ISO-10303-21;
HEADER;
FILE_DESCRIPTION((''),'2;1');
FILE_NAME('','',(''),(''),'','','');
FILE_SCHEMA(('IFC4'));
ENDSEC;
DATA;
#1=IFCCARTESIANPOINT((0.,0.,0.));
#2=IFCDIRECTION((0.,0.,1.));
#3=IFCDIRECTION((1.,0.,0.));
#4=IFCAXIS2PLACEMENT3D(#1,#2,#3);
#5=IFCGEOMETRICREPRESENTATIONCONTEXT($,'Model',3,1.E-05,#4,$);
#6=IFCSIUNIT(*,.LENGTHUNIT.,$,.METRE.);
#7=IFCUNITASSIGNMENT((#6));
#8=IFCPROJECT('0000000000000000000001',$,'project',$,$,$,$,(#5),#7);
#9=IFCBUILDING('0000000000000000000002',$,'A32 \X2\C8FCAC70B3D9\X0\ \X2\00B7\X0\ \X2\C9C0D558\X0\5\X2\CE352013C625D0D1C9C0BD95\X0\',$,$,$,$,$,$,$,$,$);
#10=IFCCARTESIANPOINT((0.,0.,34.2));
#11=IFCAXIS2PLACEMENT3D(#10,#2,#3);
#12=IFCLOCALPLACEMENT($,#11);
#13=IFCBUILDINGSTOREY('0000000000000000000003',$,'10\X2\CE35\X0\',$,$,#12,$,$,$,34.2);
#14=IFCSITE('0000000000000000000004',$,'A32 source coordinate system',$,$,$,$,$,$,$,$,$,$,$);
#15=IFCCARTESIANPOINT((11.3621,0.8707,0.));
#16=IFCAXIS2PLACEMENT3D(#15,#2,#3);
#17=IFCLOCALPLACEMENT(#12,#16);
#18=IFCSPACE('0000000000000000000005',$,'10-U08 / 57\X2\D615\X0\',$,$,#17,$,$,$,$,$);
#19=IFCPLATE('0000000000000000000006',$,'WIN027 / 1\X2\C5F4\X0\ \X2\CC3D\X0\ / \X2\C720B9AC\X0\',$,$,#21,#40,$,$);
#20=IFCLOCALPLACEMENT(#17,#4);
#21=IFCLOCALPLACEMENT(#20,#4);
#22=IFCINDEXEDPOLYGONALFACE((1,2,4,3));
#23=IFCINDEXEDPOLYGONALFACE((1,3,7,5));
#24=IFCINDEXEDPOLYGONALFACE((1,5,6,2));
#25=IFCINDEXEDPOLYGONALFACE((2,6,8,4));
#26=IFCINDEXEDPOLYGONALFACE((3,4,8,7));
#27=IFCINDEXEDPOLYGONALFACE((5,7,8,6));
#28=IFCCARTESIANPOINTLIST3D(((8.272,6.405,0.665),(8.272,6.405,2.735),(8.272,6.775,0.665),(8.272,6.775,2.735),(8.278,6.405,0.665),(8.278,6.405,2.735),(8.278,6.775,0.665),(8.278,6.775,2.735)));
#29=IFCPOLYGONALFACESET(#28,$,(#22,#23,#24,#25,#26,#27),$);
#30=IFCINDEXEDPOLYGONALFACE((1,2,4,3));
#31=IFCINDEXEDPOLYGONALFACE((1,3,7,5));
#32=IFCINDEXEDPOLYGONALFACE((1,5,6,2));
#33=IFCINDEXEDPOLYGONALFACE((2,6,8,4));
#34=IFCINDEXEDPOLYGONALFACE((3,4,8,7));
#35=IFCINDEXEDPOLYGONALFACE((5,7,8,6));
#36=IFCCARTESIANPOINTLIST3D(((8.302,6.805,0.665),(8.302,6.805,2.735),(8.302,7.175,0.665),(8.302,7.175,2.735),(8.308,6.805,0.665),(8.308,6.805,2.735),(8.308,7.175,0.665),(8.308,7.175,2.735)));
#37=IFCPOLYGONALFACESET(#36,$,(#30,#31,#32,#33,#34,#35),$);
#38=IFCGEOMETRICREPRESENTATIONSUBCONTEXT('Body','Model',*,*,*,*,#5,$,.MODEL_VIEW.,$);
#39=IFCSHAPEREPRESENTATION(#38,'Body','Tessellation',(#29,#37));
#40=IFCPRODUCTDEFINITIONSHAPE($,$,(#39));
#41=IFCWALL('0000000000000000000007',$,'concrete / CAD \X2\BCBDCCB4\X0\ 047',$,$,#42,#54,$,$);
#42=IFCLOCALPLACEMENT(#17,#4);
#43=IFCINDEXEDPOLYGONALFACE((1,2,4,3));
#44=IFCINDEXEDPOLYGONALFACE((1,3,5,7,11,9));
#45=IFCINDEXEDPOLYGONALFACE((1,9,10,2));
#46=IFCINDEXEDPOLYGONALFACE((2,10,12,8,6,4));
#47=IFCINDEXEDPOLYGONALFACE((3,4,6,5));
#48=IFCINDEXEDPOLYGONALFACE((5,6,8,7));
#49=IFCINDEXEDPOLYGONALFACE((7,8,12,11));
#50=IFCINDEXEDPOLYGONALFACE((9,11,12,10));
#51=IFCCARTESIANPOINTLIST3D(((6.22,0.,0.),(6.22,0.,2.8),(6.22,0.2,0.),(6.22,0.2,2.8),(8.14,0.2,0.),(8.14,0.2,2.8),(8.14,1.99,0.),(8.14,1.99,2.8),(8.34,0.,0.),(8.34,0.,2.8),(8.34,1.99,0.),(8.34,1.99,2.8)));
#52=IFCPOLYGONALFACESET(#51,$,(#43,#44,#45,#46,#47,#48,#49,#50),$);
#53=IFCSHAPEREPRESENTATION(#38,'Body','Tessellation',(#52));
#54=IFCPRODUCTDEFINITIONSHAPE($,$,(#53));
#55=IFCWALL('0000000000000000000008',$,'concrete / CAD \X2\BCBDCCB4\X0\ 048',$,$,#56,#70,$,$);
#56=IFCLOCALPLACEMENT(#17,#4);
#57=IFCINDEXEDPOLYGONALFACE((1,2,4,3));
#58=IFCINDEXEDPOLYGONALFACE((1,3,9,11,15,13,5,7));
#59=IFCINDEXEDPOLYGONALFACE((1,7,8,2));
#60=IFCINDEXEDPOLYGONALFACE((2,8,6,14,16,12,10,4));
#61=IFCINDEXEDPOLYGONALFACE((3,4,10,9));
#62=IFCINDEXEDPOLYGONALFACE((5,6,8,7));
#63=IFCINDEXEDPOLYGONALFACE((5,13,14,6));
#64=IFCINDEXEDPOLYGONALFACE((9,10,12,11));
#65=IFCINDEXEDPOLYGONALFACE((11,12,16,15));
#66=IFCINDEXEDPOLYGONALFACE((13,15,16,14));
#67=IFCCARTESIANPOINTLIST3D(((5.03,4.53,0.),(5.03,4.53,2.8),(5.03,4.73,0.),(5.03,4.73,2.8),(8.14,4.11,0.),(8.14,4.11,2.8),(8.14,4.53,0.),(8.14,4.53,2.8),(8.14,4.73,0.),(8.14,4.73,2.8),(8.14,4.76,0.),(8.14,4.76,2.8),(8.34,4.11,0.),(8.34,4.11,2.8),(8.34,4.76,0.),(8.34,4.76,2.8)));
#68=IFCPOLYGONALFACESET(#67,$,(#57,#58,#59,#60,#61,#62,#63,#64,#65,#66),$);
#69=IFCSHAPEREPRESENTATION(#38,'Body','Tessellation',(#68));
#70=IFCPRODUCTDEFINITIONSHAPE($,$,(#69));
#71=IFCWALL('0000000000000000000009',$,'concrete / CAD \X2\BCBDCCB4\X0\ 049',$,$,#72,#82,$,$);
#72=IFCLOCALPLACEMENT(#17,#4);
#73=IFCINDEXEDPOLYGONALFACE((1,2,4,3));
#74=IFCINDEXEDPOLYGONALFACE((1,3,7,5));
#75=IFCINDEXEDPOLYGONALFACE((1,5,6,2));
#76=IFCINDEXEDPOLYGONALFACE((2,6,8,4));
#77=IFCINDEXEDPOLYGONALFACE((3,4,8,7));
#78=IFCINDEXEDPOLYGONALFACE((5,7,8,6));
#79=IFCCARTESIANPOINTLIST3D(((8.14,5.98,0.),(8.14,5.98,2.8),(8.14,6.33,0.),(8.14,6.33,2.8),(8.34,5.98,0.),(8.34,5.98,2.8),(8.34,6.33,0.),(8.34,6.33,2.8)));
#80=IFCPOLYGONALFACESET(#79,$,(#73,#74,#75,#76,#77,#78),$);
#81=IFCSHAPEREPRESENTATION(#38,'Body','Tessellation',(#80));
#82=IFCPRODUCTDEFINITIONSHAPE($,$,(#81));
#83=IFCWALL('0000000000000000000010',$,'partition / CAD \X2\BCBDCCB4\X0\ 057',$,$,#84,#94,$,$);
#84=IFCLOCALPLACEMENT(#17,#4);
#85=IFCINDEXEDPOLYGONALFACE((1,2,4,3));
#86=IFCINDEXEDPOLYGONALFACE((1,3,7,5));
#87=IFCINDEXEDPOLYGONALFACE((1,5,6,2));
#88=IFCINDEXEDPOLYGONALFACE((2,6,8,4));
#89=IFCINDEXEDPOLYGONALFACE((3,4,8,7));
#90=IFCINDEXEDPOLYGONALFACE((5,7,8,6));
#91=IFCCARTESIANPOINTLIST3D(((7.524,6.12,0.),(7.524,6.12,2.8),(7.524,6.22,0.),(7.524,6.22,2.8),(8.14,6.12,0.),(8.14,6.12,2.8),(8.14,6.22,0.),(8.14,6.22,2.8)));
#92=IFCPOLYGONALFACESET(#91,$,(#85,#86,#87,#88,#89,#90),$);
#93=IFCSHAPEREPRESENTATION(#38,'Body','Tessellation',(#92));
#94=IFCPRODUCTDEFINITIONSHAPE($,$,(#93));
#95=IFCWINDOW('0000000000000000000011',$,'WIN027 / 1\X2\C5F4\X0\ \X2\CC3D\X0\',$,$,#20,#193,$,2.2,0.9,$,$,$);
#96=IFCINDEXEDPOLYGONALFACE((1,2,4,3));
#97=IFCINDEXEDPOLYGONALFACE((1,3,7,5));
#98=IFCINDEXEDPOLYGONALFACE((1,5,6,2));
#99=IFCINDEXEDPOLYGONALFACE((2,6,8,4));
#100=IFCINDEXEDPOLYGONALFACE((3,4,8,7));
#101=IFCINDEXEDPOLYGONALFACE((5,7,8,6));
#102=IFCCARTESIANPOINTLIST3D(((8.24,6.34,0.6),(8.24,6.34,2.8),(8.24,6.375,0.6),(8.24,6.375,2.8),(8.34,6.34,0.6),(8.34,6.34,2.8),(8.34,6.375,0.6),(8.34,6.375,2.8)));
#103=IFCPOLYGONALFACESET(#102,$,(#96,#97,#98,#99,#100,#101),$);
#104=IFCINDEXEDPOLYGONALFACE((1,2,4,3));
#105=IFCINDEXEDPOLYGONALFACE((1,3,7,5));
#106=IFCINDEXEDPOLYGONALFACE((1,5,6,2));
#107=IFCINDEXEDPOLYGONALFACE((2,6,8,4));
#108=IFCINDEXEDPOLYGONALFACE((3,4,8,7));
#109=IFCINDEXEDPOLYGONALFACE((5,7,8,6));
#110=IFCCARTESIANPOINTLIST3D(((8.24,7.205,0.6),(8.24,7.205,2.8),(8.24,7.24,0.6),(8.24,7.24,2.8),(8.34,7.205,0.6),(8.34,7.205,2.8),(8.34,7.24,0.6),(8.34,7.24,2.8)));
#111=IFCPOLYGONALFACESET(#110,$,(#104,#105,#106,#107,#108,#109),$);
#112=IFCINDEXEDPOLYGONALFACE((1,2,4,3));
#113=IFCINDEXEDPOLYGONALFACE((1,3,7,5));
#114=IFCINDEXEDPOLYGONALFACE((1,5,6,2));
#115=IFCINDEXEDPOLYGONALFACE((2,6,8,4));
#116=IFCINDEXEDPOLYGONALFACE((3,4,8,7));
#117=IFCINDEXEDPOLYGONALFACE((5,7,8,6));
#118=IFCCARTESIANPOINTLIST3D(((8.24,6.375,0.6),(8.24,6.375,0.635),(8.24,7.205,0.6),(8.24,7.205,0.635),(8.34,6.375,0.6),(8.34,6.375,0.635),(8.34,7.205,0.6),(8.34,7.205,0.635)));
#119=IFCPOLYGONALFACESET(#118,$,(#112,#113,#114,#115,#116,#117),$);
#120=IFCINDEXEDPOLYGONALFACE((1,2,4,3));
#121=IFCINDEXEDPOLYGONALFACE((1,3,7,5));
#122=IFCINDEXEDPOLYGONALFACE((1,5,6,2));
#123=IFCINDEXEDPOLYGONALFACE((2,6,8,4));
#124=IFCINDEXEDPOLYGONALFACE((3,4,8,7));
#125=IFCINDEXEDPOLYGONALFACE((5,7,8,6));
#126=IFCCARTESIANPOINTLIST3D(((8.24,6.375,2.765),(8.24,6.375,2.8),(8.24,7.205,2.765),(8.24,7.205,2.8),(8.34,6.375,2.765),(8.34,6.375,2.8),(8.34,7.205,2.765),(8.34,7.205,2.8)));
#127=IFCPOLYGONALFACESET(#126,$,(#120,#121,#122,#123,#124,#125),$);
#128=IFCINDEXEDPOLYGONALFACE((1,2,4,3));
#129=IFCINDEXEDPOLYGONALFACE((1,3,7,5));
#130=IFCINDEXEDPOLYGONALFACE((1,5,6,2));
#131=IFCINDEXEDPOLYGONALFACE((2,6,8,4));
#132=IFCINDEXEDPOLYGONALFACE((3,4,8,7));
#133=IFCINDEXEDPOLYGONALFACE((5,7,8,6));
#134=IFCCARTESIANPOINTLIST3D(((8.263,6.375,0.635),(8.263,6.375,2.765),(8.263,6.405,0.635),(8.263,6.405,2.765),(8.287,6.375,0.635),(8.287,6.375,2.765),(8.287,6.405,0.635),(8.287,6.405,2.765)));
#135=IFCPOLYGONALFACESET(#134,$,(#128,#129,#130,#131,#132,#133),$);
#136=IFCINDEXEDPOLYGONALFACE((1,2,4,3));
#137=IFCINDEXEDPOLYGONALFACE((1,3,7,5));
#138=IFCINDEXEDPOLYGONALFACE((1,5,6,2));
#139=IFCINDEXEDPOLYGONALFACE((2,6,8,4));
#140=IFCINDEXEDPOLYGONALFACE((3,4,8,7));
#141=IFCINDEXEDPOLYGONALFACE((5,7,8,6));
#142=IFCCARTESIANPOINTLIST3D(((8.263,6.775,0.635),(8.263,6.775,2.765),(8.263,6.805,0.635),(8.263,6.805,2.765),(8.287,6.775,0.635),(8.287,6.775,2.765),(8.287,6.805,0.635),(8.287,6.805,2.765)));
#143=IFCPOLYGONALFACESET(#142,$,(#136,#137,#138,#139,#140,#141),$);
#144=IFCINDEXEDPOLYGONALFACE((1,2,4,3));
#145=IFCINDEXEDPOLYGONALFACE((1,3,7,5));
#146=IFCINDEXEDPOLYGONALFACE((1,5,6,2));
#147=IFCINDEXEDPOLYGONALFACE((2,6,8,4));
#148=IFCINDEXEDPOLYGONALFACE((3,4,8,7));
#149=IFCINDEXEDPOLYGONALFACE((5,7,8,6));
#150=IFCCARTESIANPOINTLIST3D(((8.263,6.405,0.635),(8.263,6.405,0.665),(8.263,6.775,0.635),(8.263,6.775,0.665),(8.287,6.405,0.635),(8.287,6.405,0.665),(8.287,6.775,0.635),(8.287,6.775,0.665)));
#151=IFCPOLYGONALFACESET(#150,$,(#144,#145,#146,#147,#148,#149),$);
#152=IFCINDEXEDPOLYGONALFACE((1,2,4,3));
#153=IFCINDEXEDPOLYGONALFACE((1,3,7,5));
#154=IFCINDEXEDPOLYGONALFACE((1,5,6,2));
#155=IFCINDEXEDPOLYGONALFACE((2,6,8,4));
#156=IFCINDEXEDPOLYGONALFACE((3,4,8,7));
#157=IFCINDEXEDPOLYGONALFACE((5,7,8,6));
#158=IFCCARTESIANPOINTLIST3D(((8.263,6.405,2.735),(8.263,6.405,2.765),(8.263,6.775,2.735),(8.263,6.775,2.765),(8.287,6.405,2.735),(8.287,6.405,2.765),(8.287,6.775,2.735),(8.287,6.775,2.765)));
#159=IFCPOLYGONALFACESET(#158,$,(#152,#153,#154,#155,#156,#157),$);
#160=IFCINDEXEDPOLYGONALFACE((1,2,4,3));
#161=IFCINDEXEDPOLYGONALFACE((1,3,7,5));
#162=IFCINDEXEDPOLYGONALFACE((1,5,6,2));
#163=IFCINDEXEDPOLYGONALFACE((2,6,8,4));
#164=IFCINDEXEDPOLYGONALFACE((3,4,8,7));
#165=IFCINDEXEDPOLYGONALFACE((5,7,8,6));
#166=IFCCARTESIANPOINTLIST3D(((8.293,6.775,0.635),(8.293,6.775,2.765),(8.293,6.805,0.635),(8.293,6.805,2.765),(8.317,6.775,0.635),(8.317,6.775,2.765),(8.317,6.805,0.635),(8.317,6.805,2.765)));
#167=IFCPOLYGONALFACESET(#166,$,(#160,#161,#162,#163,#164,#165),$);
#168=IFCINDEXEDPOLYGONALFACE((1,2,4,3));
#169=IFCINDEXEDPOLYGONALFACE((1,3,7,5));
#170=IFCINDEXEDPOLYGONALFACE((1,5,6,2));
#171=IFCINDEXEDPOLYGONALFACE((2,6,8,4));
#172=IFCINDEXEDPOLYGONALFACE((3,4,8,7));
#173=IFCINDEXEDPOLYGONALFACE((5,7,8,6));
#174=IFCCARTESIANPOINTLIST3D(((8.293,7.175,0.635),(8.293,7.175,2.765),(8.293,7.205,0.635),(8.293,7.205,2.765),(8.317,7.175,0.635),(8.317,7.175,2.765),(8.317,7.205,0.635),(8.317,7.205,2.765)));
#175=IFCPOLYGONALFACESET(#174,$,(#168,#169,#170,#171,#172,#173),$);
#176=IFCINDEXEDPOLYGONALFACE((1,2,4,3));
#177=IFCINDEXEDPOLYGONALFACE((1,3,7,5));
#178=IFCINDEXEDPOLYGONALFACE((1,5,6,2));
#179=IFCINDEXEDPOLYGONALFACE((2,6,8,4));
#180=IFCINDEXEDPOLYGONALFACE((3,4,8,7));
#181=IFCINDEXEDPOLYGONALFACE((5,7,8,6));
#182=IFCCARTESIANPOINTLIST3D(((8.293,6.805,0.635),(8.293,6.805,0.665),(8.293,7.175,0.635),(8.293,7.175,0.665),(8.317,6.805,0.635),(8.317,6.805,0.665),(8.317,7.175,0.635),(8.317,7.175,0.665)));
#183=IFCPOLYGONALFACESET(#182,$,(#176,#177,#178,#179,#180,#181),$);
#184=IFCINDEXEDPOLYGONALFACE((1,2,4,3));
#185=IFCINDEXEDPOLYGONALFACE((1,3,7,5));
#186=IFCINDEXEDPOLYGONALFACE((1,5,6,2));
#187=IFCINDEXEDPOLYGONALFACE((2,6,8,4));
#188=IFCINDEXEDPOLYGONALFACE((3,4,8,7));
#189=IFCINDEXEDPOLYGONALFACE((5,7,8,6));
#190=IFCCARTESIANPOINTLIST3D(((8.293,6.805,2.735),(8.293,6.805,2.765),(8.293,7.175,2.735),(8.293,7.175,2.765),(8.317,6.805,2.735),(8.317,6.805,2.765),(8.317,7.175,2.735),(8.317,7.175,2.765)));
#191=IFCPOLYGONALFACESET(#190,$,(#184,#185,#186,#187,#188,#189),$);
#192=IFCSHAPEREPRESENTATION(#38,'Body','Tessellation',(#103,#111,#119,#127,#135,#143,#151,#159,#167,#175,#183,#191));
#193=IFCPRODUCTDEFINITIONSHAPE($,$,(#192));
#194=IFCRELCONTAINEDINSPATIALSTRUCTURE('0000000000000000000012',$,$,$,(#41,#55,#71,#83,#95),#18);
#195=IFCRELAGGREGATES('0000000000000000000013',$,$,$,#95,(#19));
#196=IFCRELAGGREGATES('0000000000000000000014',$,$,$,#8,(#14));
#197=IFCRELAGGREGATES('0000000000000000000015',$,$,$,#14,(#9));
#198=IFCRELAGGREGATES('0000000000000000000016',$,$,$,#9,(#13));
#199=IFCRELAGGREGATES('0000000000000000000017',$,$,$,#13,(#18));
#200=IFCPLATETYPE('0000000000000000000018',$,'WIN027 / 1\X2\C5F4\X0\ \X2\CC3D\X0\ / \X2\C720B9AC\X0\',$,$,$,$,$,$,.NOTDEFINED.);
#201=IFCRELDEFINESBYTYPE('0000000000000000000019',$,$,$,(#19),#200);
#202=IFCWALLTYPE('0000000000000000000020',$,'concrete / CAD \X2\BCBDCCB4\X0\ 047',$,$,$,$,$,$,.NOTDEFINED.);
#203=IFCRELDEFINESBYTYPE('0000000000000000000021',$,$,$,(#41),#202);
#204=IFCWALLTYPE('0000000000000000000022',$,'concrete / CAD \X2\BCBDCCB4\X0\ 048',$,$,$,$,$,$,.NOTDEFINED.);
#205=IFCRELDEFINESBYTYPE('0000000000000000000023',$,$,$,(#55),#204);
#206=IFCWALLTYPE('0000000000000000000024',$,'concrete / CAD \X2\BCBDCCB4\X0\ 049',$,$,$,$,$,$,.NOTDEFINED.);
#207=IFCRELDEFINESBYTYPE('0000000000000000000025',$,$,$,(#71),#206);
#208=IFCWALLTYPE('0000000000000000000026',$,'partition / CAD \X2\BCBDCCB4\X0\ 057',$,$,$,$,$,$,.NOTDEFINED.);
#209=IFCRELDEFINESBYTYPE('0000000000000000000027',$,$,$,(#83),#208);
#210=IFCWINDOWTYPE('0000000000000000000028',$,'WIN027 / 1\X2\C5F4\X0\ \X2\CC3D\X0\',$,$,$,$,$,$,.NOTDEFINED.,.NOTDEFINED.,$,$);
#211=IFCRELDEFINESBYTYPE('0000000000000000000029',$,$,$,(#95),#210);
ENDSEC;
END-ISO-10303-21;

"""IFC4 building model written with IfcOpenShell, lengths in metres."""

from ifc_helpers import new_model, si_unit, frame, origin, origin_with_axes, place, context, subcontext, project, spatial, polyline, outline, extrude, source, transform, mapped, type_object, type_shapes, element, aggregate, save


model = new_model("IFC4")

# Units and contexts
model_context = context("Model", 3, precision=1e-05, world=origin_with_axes())
body_context = subcontext(model_context, "Body", "Model", "MODEL_VIEW")
ifc_project = project(units=[si_unit("LENGTHUNIT", "METRE")], contexts=[model_context])

# Plate
storey_placement = place(None, frame((0.0, 0.0, 34.2), z_axis=(0.0, 0.0, 1.0), x_axis=(1.0, 0.0, 0.0)))
space_placement = place(storey_placement, frame((11.3621, 0.8707, 0.0), z_axis=(0.0, 0.0, 1.0), x_axis=(1.0, 0.0, 0.0)))
plate_type_1 = type_object("IfcPlateType", Name="WIN027 / 1열 창 / 유리", PredefinedType="NOTDEFINED")
shared_shape_1 = source(origin(), body_context, "Body", "SweptSolid", [
    extrude(outline(polyline([(8.272, 6.405), (8.272, 6.775), (8.278, 6.775), (8.278, 6.405), (8.272, 6.405)])), frame((0.0, 0.0, 0.665)), (0.0, 0.0, 1.0), 2.07),
    extrude(outline(polyline([(8.302, 6.805), (8.302, 7.175), (8.308, 7.175), (8.308, 6.805), (8.302, 6.805)])), frame((0.0, 0.0, 0.665)), (0.0, 0.0, 1.0), 2.07),
])
type_shapes(plate_type_1, [shared_shape_1])
window_1_placement = place(space_placement, origin_with_axes())
plate_1_placement = place(window_1_placement, origin_with_axes())
plate_1 = element("IfcPlate", 1, at=plate_1_placement, type_object=plate_type_1, Name="WIN027 / 1열 창 / 유리", context=body_context, shape_type="MappedRepresentation", body=[
    mapped(shared_shape_1, transform((0.0, 0.0, 0.0), scale=1.0)),
])

# Site, building, storey, space
site = spatial("IfcSite", under=ifc_project, Name="A32 source coordinate system")
building = spatial("IfcBuilding", under=site, Name="A32 주거동 · 지하5층–옥탑지붕")
storey = spatial("IfcBuildingStorey", under=building, at=storey_placement, Name="10층", Elevation=34.2)
space = spatial("IfcSpace", under=storey, at=space_placement, Name="10-U08 / 57형")

# Walls
wall_type_1 = type_object("IfcWallType", Name="concrete / CAD 벽체 047", PredefinedType="NOTDEFINED")
shared_shape_2 = source(origin(), body_context, "Body", "SweptSolid", [
    extrude(outline(polyline([(8.14, 1.99), (8.34, 1.99), (8.34, 0.0), (6.22, 0.0), (6.22, 0.2), (8.14, 0.2), (8.14, 1.99)])), origin(), (0.0, 0.0, 1.0), 2.8),
])
type_shapes(wall_type_1, [shared_shape_2])
wall_1_placement = place(space_placement, origin_with_axes())
element("IfcWall", 2, at=wall_1_placement, inside=space, type_object=wall_type_1, Name="concrete / CAD 벽체 047", context=body_context, shape_type="MappedRepresentation", body=[
    mapped(shared_shape_2, transform((0.0, 0.0, 0.0), scale=1.0)),
])
wall_type_2 = type_object("IfcWallType", Name="concrete / CAD 벽체 048", PredefinedType="NOTDEFINED")
shared_shape_3 = source(origin(), body_context, "Body", "SweptSolid", [
    extrude(outline(polyline([(8.14, 4.53), (5.03, 4.53), (5.03, 4.73), (8.14, 4.73), (8.14, 4.76), (8.34, 4.76), (8.34, 4.11), (8.14, 4.11), (8.14, 4.53)])), origin(), (0.0, 0.0, 1.0), 2.8),
])
type_shapes(wall_type_2, [shared_shape_3])
wall_2_placement = place(space_placement, origin_with_axes())
element("IfcWall", 3, at=wall_2_placement, inside=space, type_object=wall_type_2, Name="concrete / CAD 벽체 048", context=body_context, shape_type="MappedRepresentation", body=[
    mapped(shared_shape_3, transform((0.0, 0.0, 0.0), scale=1.0)),
])
wall_type_3 = type_object("IfcWallType", Name="concrete / CAD 벽체 049", PredefinedType="NOTDEFINED")
shared_shape_4 = source(origin(), body_context, "Body", "SweptSolid", [
    extrude(outline(polyline([(8.34, 6.33), (8.34, 5.98), (8.14, 5.98), (8.14, 6.33), (8.34, 6.33)])), origin(), (0.0, 0.0, 1.0), 2.8),
])
type_shapes(wall_type_3, [shared_shape_4])
wall_3_placement = place(space_placement, origin_with_axes())
element("IfcWall", 4, at=wall_3_placement, inside=space, type_object=wall_type_3, Name="concrete / CAD 벽체 049", context=body_context, shape_type="MappedRepresentation", body=[
    mapped(shared_shape_4, transform((0.0, 0.0, 0.0), scale=1.0)),
])
wall_type_4 = type_object("IfcWallType", Name="partition / CAD 벽체 057", PredefinedType="NOTDEFINED")
shared_shape_5 = source(origin(), body_context, "Body", "SweptSolid", [
    extrude(outline(polyline([(7.524, 6.22), (8.14, 6.22), (8.14, 6.12), (7.524, 6.12), (7.524, 6.22)])), origin(), (0.0, 0.0, 1.0), 2.8),
])
type_shapes(wall_type_4, [shared_shape_5])
wall_4_placement = place(space_placement, origin_with_axes())
element("IfcWall", 5, at=wall_4_placement, inside=space, type_object=wall_type_4, Name="partition / CAD 벽체 057", context=body_context, shape_type="MappedRepresentation", body=[
    mapped(shared_shape_5, transform((0.0, 0.0, 0.0), scale=1.0)),
])

# Window
window_type_1 = type_object("IfcWindowType", Name="WIN027 / 1열 창", PartitioningType="NOTDEFINED", PredefinedType="NOTDEFINED")
shared_shape_6 = source(origin(), body_context, "Body", "SweptSolid", [
    extrude(outline(polyline([(8.24, 6.34), (8.24, 6.375), (8.34, 6.375), (8.34, 6.34), (8.24, 6.34)])), frame((0.0, 0.0, 0.6)), (0.0, 0.0, 1.0), 2.2),
    extrude(outline(polyline([(8.24, 7.205), (8.24, 7.24), (8.34, 7.24), (8.34, 7.205), (8.24, 7.205)])), frame((0.0, 0.0, 0.6)), (0.0, 0.0, 1.0), 2.2),
    extrude(outline(polyline([(8.24, 6.375), (8.24, 7.205), (8.34, 7.205), (8.34, 6.375), (8.24, 6.375)])), frame((0.0, 0.0, 0.6)), (0.0, 0.0, 1.0), 0.035),
    extrude(outline(polyline([(8.24, 6.375), (8.24, 7.205), (8.34, 7.205), (8.34, 6.375), (8.24, 6.375)])), frame((0.0, 0.0, 2.765)), (0.0, 0.0, 1.0), 0.035),
    extrude(outline(polyline([(8.263, 6.375), (8.263, 6.405), (8.287, 6.405), (8.287, 6.375), (8.263, 6.375)])), frame((0.0, 0.0, 0.635)), (0.0, 0.0, 1.0), 2.13),
    extrude(outline(polyline([(8.263, 6.775), (8.263, 6.805), (8.287, 6.805), (8.287, 6.775), (8.263, 6.775)])), frame((0.0, 0.0, 0.635)), (0.0, 0.0, 1.0), 2.13),
    extrude(outline(polyline([(8.263, 6.405), (8.263, 6.775), (8.287, 6.775), (8.287, 6.405), (8.263, 6.405)])), frame((0.0, 0.0, 0.635)), (0.0, 0.0, 1.0), 0.03),
    extrude(outline(polyline([(8.263, 6.405), (8.263, 6.775), (8.287, 6.775), (8.287, 6.405), (8.263, 6.405)])), frame((0.0, 0.0, 2.735)), (0.0, 0.0, 1.0), 0.03),
    extrude(outline(polyline([(8.293, 6.775), (8.293, 6.805), (8.317, 6.805), (8.317, 6.775), (8.293, 6.775)])), frame((0.0, 0.0, 0.635)), (0.0, 0.0, 1.0), 2.13),
    extrude(outline(polyline([(8.293, 7.175), (8.293, 7.205), (8.317, 7.205), (8.317, 7.175), (8.293, 7.175)])), frame((0.0, 0.0, 0.635)), (0.0, 0.0, 1.0), 2.13),
    extrude(outline(polyline([(8.293, 6.805), (8.293, 7.175), (8.317, 7.175), (8.317, 6.805), (8.293, 6.805)])), frame((0.0, 0.0, 0.635)), (0.0, 0.0, 1.0), 0.03),
    extrude(outline(polyline([(8.293, 6.805), (8.293, 7.175), (8.317, 7.175), (8.317, 6.805), (8.293, 6.805)])), frame((0.0, 0.0, 2.735)), (0.0, 0.0, 1.0), 0.03),
])
type_shapes(window_type_1, [shared_shape_6])
window_1 = element("IfcWindow", 6, at=window_1_placement, inside=space, type_object=window_type_1, Name="WIN027 / 1열 창", OverallHeight=2.2, OverallWidth=0.9, context=body_context, shape_type="MappedRepresentation", body=[
    mapped(shared_shape_6, transform((0.0, 0.0, 0.0), scale=1.0)),
])
aggregate(window_1, [plate_1])

save(model, "model.ifc")
